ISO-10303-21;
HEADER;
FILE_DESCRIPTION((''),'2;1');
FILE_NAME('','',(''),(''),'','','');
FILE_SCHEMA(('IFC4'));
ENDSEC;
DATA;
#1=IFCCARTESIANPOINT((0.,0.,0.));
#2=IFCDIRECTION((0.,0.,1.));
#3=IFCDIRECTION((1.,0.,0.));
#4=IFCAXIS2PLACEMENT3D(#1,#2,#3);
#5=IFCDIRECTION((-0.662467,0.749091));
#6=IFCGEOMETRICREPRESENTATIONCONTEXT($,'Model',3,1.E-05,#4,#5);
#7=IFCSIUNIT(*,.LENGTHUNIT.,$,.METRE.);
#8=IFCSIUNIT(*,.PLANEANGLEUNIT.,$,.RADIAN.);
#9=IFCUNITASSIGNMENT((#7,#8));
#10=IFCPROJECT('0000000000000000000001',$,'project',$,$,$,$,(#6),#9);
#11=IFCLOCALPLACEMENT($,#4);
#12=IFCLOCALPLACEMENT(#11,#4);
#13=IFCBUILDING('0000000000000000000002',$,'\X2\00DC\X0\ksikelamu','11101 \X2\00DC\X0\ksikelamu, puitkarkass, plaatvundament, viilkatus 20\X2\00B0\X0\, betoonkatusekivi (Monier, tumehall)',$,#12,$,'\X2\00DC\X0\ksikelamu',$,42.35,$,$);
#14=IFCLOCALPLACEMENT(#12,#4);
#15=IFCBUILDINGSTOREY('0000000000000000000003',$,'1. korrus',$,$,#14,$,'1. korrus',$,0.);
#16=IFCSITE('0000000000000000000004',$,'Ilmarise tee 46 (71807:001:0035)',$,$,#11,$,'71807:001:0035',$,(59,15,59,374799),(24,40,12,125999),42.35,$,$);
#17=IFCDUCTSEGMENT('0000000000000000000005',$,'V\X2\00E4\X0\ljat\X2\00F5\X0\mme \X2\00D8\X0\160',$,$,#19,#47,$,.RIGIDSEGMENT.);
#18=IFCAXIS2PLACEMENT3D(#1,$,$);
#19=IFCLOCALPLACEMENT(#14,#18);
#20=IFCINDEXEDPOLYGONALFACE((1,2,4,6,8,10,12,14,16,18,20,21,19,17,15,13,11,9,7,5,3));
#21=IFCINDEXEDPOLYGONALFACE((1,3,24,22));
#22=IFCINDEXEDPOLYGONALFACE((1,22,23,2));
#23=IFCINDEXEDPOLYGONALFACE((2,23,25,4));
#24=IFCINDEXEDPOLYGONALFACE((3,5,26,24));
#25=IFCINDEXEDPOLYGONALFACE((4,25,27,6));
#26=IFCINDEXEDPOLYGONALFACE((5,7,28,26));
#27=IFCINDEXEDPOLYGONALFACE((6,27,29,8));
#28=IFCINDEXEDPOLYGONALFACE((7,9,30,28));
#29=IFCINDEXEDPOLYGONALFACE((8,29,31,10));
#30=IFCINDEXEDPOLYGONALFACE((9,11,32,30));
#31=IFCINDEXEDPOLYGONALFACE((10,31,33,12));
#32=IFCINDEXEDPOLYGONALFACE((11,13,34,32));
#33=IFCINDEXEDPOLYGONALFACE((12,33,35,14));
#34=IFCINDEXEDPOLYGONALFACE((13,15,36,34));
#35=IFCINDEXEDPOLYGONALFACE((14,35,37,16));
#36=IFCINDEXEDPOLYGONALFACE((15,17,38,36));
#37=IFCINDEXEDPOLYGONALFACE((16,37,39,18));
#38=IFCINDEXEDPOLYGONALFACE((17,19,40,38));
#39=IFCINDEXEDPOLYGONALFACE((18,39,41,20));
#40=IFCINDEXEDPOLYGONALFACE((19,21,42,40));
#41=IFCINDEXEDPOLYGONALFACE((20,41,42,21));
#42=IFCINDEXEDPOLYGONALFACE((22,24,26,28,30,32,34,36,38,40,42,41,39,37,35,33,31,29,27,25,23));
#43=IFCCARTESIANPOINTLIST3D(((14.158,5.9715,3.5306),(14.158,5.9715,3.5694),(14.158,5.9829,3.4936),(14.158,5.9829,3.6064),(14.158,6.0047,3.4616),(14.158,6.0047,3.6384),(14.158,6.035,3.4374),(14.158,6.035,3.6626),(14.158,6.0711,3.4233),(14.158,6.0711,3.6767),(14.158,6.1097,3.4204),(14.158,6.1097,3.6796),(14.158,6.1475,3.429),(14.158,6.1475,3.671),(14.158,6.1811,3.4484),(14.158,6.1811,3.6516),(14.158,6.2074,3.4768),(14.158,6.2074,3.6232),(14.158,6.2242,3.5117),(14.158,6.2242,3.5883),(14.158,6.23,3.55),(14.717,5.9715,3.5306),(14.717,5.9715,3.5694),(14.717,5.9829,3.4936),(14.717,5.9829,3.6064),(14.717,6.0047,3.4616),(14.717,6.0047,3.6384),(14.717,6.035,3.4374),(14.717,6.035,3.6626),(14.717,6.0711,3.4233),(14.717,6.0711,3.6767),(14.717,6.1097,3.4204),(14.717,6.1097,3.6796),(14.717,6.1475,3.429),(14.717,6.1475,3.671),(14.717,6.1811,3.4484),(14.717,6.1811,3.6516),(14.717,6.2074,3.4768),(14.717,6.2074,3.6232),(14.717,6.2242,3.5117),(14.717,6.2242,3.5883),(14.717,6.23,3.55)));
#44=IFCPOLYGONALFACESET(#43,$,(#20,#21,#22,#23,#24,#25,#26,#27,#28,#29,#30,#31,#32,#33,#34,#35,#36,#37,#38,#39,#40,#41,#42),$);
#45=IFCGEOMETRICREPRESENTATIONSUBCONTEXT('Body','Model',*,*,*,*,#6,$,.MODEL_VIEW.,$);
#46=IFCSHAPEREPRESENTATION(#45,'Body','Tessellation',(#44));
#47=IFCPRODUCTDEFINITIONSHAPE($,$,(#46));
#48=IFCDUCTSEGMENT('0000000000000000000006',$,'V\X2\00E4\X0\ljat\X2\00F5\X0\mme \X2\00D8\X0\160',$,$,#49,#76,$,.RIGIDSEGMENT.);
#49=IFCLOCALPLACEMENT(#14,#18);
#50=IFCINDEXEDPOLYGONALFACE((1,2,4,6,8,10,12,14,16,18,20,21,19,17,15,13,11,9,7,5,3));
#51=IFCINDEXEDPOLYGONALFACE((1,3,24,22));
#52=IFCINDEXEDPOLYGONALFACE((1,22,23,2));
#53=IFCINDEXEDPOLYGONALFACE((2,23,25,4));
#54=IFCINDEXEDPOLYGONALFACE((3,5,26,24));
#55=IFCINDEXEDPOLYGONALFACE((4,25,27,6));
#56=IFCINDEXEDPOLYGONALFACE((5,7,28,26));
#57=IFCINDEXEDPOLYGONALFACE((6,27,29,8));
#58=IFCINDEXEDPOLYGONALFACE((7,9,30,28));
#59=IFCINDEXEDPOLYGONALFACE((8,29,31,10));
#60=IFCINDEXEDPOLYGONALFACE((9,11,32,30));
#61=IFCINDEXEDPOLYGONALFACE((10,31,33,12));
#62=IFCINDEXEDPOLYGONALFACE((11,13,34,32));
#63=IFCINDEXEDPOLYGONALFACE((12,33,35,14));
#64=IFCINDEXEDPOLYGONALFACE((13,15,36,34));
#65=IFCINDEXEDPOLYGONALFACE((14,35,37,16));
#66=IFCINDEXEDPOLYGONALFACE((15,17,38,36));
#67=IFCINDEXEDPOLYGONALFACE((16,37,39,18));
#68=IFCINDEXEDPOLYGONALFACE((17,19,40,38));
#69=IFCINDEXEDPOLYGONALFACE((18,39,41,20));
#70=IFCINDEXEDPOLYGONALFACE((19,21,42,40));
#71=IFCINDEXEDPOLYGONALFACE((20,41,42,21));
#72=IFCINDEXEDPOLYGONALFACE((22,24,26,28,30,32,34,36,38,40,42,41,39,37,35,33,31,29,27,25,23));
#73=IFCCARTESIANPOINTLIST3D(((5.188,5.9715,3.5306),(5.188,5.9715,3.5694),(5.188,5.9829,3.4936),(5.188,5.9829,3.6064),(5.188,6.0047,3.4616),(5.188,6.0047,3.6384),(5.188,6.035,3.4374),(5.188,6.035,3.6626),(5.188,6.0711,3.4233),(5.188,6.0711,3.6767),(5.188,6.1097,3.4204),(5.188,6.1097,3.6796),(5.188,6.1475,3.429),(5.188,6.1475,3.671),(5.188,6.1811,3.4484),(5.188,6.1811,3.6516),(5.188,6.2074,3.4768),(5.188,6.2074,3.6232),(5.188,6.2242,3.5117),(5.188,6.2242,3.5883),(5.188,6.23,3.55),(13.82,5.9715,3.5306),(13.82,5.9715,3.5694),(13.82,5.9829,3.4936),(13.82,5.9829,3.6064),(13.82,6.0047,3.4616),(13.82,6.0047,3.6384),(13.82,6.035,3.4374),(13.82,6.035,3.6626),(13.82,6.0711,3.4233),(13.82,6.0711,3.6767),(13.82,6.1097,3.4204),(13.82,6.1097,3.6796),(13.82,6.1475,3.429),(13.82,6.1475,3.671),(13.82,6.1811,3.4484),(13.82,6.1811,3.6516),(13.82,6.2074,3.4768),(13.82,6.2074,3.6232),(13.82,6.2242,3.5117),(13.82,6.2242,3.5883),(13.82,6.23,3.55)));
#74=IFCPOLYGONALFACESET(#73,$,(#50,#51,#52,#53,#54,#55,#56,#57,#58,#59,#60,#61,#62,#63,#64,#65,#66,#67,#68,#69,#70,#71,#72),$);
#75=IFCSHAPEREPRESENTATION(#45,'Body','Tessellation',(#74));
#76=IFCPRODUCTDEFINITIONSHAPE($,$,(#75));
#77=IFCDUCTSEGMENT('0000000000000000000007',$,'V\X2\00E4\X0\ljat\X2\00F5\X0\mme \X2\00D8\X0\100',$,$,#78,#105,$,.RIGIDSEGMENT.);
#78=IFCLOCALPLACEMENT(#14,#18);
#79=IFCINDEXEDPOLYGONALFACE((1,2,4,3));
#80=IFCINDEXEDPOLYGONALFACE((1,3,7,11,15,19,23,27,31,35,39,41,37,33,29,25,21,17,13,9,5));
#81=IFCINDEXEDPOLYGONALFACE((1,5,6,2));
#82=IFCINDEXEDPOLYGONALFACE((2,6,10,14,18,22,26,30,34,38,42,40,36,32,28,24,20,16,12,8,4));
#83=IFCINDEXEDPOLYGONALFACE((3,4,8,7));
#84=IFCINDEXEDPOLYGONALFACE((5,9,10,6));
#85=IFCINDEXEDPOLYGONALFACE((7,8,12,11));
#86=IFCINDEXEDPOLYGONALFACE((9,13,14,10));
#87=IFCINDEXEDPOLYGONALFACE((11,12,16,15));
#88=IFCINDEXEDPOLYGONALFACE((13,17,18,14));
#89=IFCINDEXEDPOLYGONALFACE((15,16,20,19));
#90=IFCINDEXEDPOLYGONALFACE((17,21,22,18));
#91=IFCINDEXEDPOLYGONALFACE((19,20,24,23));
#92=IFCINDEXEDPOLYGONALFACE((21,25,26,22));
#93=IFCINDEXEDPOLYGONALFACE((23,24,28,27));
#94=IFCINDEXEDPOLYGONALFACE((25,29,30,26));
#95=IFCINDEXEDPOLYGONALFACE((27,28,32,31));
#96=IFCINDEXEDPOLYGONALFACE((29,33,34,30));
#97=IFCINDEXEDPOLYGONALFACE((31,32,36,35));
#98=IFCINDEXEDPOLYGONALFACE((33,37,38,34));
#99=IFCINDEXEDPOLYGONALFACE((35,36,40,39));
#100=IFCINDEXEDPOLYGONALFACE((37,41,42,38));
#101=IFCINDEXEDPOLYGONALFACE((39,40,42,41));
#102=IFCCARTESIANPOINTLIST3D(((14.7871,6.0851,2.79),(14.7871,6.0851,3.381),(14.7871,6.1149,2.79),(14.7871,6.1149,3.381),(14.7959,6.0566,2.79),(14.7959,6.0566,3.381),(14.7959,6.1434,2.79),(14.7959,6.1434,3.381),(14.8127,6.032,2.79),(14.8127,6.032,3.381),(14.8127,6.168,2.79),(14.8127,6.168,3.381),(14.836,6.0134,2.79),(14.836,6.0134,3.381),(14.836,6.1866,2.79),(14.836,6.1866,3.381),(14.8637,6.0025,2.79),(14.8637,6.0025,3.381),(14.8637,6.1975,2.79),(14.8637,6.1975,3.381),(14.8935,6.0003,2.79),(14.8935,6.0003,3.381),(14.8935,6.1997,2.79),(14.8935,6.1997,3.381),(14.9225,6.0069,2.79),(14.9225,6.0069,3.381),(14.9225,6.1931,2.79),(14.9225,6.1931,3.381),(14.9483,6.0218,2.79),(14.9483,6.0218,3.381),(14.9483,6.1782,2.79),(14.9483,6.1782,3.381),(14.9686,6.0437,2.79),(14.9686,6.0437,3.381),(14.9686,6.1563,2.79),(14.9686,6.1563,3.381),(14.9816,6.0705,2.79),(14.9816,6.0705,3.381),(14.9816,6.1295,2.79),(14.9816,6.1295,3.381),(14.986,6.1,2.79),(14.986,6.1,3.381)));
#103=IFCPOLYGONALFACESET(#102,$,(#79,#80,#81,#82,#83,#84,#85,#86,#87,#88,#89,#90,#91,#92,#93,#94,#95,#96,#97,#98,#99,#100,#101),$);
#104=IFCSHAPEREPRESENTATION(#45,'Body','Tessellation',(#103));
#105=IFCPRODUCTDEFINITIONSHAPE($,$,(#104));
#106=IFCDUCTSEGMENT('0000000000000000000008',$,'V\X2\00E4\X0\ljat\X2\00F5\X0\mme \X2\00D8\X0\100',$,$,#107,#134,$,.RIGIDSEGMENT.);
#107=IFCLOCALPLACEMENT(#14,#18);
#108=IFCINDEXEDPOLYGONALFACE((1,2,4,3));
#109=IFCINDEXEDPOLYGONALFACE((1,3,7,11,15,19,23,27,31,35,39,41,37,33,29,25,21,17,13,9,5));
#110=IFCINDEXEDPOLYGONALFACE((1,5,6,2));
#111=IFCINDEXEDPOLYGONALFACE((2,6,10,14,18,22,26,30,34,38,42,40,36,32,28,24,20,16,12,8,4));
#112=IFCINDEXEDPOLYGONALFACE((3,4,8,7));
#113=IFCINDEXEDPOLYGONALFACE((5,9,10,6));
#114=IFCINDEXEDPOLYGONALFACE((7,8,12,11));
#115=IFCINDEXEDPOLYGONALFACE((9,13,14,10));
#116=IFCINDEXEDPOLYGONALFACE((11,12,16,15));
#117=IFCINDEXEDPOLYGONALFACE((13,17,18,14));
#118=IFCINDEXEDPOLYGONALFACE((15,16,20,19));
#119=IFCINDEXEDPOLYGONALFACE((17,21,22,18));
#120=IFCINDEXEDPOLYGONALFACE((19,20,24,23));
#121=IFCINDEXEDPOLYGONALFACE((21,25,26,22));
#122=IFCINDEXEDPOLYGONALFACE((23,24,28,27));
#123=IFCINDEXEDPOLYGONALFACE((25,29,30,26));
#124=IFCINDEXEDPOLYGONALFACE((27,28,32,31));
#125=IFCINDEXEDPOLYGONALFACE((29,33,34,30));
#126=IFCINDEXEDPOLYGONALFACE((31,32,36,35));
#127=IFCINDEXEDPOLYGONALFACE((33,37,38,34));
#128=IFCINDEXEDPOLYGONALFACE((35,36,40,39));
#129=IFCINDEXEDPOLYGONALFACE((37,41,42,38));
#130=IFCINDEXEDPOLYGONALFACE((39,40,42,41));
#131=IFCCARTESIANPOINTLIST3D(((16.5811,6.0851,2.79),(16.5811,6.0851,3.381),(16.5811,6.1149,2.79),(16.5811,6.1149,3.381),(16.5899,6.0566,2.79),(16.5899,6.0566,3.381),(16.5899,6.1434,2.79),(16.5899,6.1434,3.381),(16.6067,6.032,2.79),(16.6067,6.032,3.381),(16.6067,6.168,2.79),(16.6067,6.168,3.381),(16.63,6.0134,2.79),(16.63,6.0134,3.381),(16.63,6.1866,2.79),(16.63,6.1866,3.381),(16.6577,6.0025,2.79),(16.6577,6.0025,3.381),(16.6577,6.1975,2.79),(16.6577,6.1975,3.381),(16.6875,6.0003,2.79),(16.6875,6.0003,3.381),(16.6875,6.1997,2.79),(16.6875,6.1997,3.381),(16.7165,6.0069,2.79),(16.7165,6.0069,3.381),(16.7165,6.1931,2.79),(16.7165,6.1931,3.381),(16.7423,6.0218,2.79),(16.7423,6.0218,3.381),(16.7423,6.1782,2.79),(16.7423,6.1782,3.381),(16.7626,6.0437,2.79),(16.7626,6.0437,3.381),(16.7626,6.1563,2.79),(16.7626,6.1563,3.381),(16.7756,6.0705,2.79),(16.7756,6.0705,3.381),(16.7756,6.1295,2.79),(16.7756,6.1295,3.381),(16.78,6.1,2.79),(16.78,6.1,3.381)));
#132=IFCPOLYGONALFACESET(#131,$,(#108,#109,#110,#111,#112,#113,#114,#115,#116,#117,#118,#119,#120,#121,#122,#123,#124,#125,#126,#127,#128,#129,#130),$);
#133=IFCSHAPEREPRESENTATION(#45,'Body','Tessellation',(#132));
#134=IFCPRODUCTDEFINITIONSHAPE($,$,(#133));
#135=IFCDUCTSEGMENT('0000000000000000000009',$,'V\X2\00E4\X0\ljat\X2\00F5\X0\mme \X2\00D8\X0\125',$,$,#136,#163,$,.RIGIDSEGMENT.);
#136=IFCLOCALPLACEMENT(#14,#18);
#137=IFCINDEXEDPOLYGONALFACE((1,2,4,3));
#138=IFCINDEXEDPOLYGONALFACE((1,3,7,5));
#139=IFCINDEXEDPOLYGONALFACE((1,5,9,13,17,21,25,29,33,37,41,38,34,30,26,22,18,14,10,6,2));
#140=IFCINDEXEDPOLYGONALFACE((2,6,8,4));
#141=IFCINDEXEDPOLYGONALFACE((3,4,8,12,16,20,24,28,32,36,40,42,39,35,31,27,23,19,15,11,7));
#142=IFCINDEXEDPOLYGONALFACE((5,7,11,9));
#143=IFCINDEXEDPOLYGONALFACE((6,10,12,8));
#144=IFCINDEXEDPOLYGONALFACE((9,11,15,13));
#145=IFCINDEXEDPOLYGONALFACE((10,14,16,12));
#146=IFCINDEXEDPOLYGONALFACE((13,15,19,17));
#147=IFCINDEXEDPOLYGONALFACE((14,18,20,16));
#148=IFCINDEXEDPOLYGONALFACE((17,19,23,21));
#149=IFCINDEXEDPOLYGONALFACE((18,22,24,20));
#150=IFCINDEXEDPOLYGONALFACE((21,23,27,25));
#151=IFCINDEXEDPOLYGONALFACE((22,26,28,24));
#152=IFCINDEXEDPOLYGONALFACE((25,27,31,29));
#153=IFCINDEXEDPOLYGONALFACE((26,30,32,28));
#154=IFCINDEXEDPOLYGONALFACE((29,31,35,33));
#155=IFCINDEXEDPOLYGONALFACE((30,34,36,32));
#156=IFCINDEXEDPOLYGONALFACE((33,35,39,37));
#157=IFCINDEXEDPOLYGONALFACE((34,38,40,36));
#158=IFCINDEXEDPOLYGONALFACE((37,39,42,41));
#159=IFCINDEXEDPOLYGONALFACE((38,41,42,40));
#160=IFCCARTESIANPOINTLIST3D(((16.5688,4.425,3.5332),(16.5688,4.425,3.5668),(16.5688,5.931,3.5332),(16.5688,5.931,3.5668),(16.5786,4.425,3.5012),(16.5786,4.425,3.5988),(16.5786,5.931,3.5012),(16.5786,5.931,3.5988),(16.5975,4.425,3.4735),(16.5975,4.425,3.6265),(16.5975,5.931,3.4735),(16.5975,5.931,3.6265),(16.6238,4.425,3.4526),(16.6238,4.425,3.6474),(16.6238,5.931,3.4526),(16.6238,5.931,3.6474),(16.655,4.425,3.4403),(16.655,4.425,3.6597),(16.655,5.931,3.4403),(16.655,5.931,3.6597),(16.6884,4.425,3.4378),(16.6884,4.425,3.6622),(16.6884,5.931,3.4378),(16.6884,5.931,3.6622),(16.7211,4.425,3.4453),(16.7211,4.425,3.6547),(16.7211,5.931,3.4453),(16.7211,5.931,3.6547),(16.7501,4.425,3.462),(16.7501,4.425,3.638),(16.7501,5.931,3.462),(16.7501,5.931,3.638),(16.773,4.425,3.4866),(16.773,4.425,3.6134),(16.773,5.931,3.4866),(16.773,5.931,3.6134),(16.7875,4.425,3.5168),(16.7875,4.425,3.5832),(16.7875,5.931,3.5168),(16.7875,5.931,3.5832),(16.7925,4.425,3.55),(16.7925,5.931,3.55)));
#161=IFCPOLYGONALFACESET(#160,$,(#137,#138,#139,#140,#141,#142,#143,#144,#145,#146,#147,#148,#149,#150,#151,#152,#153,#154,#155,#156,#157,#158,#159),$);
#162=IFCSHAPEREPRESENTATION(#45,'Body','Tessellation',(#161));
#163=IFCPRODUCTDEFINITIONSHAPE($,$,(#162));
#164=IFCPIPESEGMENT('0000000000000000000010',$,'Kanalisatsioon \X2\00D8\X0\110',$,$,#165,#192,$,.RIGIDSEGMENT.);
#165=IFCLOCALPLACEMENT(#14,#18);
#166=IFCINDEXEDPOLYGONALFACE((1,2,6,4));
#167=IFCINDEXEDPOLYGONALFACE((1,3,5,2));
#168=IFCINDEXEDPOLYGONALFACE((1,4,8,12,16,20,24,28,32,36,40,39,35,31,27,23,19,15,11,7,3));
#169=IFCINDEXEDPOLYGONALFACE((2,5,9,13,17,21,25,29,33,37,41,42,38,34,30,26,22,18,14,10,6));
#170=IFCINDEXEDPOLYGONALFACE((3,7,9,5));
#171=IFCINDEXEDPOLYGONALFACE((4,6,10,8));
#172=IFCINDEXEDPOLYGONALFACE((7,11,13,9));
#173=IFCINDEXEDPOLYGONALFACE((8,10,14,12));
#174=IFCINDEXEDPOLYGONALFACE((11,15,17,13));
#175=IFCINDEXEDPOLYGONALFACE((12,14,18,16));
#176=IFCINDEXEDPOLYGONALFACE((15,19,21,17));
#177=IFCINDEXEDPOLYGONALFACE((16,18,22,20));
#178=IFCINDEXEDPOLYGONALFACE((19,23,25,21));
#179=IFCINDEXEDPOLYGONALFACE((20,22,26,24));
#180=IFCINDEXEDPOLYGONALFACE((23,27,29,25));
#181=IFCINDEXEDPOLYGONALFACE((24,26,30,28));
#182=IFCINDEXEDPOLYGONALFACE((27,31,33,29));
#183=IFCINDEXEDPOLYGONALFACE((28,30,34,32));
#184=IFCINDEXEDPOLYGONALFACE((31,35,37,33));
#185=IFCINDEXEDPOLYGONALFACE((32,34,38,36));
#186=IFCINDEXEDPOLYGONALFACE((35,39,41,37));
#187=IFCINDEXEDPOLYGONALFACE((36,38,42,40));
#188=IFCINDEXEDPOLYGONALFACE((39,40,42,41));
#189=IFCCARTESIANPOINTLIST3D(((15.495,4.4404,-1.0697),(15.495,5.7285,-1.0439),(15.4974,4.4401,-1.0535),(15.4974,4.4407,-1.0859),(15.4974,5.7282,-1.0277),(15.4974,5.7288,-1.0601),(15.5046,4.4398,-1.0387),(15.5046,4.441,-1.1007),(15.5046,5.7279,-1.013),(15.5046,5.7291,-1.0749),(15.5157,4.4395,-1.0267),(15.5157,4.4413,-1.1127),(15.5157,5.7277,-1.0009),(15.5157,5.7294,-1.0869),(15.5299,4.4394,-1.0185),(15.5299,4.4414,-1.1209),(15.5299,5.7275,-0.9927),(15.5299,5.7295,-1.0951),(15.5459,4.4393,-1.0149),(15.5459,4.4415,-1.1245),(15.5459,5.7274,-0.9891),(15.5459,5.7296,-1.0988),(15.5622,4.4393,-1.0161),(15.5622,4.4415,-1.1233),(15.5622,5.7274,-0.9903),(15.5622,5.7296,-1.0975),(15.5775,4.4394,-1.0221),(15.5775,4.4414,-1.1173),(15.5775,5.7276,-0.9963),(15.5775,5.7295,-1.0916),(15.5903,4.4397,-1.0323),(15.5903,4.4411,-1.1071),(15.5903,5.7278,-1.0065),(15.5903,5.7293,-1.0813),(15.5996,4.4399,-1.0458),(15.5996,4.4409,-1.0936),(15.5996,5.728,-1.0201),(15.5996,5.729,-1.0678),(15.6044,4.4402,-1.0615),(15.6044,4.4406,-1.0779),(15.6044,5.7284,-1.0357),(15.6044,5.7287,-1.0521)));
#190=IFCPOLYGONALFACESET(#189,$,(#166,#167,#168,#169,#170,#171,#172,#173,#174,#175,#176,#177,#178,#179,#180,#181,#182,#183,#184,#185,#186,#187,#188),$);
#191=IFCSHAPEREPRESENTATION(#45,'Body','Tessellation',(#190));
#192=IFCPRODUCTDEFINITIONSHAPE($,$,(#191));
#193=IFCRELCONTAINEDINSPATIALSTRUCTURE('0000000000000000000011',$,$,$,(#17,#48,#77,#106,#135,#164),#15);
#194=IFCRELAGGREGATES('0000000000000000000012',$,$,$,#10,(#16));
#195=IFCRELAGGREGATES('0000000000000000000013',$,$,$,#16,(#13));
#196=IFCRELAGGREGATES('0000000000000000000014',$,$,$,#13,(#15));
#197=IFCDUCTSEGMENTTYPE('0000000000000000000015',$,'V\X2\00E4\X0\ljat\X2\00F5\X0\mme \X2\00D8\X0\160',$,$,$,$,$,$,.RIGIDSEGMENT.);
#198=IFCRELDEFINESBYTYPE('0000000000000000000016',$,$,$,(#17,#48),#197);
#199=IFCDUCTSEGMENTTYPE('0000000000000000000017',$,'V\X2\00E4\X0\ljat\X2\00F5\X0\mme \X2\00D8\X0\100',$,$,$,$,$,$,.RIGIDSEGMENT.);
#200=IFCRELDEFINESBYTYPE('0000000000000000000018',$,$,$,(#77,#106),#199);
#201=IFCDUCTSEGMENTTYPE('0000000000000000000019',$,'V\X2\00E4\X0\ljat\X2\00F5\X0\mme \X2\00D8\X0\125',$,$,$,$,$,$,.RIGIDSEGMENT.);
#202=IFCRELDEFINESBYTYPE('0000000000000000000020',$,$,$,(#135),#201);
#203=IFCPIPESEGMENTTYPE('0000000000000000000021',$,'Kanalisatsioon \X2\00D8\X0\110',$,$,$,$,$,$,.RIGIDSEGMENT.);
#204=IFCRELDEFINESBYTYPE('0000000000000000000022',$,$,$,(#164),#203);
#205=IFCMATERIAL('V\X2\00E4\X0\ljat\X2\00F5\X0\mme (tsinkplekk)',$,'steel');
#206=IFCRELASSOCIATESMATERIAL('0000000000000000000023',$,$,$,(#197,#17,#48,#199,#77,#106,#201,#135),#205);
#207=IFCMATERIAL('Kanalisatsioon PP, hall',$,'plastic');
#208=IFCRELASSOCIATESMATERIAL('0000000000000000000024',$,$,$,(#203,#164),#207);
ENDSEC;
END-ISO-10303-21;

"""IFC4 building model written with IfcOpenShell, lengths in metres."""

from ifc_helpers import new_model, si_unit, direction, frame, origin_with_axes, place, context, subcontext, project, spatial, circle, extrude, material, type_object, element, save


model = new_model("IFC4")

# Units and contexts
model_context = context("Model", 3, precision=1e-05, world=origin_with_axes(), true_north=direction((-0.662467, 0.749091)))
body_context = subcontext(model_context, "Body", "Model", "MODEL_VIEW")
ifc_project = project(units=[si_unit("LENGTHUNIT", "METRE"), si_unit("PLANEANGLEUNIT", "RADIAN")], contexts=[model_context])

# Site, building, storey
site_placement = place(None, origin_with_axes())
site = spatial("IfcSite", under=ifc_project, at=site_placement, Name="Ilmarise tee 46 (71807:001:0035)", LongName="71807:001:0035", RefLatitude=(59, 15, 59, 374799), RefLongitude=(24, 40, 12, 125999), RefElevation=42.35)
building_placement = place(site_placement, origin_with_axes())
building = spatial("IfcBuilding", under=site, at=building_placement, Name="Üksikelamu", Description="11101 Üksikelamu, puitkarkass, plaatvundament, viilkatus 20°, betoonkatusekivi (Monier, tumehall)", LongName="Üksikelamu", ElevationOfRefHeight=42.35)
storey_placement = place(building_placement, origin_with_axes())
storey = spatial("IfcBuildingStorey", under=building, at=storey_placement, Name="1. korrus", LongName="1. korrus", Elevation=0.0)

# Shared definitions
ifc_material_1 = material(Name="Väljatõmme (tsinkplekk)", Category="steel")

# Shared definitions
ifc_material_2 = material(Name="Kanalisatsioon PP, hall", Category="plastic")

# Duct segments
duct_segment_type_1 = type_object("IfcDuctSegmentType", Name="Väljatõmme Ø160", PredefinedType="RIGIDSEGMENT", material=ifc_material_1)
duct_segment_1_placement = place(storey_placement, frame((14.717, 6.1, 3.55), z_axis=(-1.0, 0.0, 0.0), x_axis=(0.0, 1.0, 0.0)))
element("IfcDuctSegment", 1, at=duct_segment_1_placement, inside=storey, type_object=duct_segment_type_1, material=ifc_material_1, Name="Väljatõmme Ø160", PredefinedType="RIGIDSEGMENT", context=body_context, shape_type="SweptSolid", body=[
    extrude(circle(Radius=0.13), origin_with_axes(), (0.0, 0.0, 1.0), 0.559),
])
duct_segment_2_placement = place(storey_placement, frame((13.82, 6.1, 3.55), z_axis=(-1.0, 0.0, 0.0), x_axis=(0.0, 1.0, 0.0)))
element("IfcDuctSegment", 2, at=duct_segment_2_placement, inside=storey, type_object=duct_segment_type_1, material=ifc_material_1, Name="Väljatõmme Ø160", PredefinedType="RIGIDSEGMENT", context=body_context, shape_type="SweptSolid", body=[
    extrude(circle(Radius=0.13), origin_with_axes(), (0.0, 0.0, 1.0), 8.632),
])
duct_segment_type_2 = type_object("IfcDuctSegmentType", Name="Väljatõmme Ø100", PredefinedType="RIGIDSEGMENT", material=ifc_material_1)
for number, where, z_axis, x_axis, name in (
    (3, (14.886, 6.1, 2.79), (0.0, 0.0, 1.0), (1.0, 0.0, 0.0), "Väljatõmme Ø100"),
    (4, (16.68, 6.1, 2.79), (0.0, 0.0, 1.0), (1.0, 0.0, 0.0), "Väljatõmme Ø100"),
):
    element("IfcDuctSegment", number, at=place(storey_placement, frame(where, z_axis=z_axis, x_axis=x_axis)), inside=storey, type_object=duct_segment_type_2, material=ifc_material_1, Name=name, PredefinedType="RIGIDSEGMENT", context=body_context, shape_type="SweptSolid", body=[
        extrude(circle(Radius=0.1), origin_with_axes(), (0.0, 0.0, 1.0), 0.591),
    ])
duct_segment_type_3 = type_object("IfcDuctSegmentType", Name="Väljatõmme Ø125", PredefinedType="RIGIDSEGMENT", material=ifc_material_1)
duct_segment_3_placement = place(storey_placement, frame((16.68, 4.425, 3.55), z_axis=(0.0, 1.0, 0.0), x_axis=(1.0, 0.0, 0.0)))
element("IfcDuctSegment", 5, at=duct_segment_3_placement, inside=storey, type_object=duct_segment_type_3, material=ifc_material_1, Name="Väljatõmme Ø125", PredefinedType="RIGIDSEGMENT", context=body_context, shape_type="SweptSolid", body=[
    extrude(circle(Radius=0.1125), origin_with_axes(), (0.0, 0.0, 1.0), 1.506),
])

# Pipe segment
pipe_segment_type_1 = type_object("IfcPipeSegmentType", Name="Kanalisatsioon Ø110", PredefinedType="RIGIDSEGMENT", material=ifc_material_2)
pipe_segment_1_placement = place(storey_placement, frame((15.55, 5.7285, -1.0439), z_axis=(0.0, -0.9998, -0.019996), x_axis=(-1.0, 0.0, 0.0)))
element("IfcPipeSegment", 6, at=pipe_segment_1_placement, inside=storey, type_object=pipe_segment_type_1, material=ifc_material_2, Name="Kanalisatsioon Ø110", PredefinedType="RIGIDSEGMENT", context=body_context, shape_type="SweptSolid", body=[
    extrude(circle(Radius=0.055), origin_with_axes(), (0.0, 0.0, 1.0), 1.2884),
])

save(model, "model.ifc")
